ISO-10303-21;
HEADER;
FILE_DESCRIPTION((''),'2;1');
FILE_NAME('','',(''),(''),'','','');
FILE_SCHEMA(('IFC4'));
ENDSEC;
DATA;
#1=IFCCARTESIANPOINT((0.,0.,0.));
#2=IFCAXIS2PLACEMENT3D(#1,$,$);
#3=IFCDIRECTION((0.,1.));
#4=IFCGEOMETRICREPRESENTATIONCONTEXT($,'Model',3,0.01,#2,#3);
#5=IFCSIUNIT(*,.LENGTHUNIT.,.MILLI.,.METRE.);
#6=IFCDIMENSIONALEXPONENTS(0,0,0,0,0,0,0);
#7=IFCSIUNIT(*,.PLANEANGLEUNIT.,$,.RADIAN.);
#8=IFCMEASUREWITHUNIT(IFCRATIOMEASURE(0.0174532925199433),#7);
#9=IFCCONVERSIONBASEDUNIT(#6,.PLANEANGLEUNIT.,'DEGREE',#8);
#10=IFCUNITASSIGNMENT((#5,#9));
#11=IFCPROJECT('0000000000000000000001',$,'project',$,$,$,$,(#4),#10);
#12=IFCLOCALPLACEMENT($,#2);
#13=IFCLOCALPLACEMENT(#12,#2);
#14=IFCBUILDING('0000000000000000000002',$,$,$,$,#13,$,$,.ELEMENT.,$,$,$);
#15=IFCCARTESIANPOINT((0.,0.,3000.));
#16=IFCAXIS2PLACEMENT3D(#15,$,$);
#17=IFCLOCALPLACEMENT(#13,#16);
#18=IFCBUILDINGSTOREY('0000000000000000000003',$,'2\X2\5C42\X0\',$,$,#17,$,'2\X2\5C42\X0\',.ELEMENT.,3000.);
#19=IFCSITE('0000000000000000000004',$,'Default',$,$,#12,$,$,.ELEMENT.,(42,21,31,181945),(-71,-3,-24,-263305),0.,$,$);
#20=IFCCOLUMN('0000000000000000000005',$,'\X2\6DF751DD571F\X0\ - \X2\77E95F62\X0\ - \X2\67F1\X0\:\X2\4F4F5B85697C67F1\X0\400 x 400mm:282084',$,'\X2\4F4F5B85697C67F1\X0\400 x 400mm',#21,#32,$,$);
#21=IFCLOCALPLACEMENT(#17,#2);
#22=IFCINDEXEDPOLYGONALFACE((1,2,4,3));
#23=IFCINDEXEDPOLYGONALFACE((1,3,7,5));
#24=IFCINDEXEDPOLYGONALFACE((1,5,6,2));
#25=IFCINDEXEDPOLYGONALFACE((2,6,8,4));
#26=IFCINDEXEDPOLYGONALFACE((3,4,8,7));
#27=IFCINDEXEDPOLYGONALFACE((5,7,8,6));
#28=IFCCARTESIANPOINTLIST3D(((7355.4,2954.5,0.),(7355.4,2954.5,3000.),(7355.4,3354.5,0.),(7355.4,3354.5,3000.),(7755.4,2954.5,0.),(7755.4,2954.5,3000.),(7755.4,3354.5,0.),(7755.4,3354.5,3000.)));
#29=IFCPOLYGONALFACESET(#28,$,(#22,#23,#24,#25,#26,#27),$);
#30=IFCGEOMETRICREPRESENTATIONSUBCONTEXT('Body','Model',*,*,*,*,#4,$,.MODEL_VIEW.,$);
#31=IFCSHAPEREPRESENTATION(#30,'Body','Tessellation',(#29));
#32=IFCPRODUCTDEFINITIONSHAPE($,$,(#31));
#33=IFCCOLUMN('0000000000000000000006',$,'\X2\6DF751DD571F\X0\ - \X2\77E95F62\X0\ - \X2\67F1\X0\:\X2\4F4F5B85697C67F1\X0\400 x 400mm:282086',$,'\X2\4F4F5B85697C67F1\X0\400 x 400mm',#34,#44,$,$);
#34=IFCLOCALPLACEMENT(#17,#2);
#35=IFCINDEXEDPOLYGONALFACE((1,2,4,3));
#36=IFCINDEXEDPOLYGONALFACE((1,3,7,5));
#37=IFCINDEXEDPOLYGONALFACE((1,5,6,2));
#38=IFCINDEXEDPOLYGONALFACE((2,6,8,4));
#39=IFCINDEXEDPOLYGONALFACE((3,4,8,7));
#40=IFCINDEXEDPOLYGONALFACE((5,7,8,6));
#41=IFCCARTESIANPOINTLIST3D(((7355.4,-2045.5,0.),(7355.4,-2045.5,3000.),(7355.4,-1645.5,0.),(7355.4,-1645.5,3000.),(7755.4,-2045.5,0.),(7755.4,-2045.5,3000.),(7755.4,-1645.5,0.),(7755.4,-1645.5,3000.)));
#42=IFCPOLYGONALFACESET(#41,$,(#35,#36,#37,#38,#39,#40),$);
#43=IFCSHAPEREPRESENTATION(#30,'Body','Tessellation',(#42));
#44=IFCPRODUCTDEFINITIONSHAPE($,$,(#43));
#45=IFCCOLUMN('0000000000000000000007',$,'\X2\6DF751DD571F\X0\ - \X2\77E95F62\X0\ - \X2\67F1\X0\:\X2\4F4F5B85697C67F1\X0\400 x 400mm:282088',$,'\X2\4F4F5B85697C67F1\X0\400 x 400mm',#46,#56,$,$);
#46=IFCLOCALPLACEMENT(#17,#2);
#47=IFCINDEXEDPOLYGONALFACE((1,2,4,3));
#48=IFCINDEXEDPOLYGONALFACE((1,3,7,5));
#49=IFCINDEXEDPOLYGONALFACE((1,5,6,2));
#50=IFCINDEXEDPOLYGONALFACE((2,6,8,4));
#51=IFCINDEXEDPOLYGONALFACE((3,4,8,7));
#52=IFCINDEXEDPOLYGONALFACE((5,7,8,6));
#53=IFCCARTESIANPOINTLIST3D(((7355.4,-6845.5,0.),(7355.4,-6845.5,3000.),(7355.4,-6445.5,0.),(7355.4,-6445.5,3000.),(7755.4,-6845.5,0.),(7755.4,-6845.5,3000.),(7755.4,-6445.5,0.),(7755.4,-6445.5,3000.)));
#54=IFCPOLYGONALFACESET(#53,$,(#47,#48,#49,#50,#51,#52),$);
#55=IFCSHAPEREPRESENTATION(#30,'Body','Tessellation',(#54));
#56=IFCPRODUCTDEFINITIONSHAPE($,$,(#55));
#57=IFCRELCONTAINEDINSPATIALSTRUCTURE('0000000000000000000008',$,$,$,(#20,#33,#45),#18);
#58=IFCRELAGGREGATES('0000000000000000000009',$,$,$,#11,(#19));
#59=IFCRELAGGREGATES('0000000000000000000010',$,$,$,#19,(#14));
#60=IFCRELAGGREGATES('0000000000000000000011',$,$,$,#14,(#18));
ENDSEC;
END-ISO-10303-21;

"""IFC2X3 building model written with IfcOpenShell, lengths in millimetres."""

from ifc_helpers import new_model, entity, si_unit, converted_unit, direction, frame, origin, origin_2d_with_axis, place, context, subcontext, project, spatial, rectangle, extrude, source, transform, mapped, element, save


model = new_model("IFC2X3")

# Units and contexts
model_context = context("Model", 3, precision=0.01, world=origin(), true_north=direction((0.0, 1.0)))
body_context = subcontext(model_context, "Body", "Model", "MODEL_VIEW")
ifc_project = project(units=[si_unit("LENGTHUNIT", "METRE", prefix="MILLI"), converted_unit("PLANEANGLEUNIT", "DEGREE", entity("IfcRatioMeasure", 0.0174532925199433), si_unit("PLANEANGLEUNIT", "RADIAN"), dimensions=[0, 0, 0, 0, 0, 0, 0])], contexts=[model_context])

# Site, building, storey
site_placement = place(None, origin())
site = spatial("IfcSite", under=ifc_project, at=site_placement, Name="Default", CompositionType="ELEMENT", RefLatitude=(42, 21, 31, 181945), RefLongitude=(-71, -3, -24, -263305), RefElevation=0.0)
building_placement = place(site_placement, origin())
building = spatial("IfcBuilding", under=site, at=building_placement, CompositionType="ELEMENT")
storey_placement = place(building_placement, frame((0.0, 0.0, 3000.0)))
storey = spatial("IfcBuildingStorey", under=building, at=storey_placement, Name="2层", LongName="2层", CompositionType="ELEMENT", Elevation=3000.0)

# Columns
shared_shape_1 = source(origin(), body_context, "Body", "SweptSolid", [
    extrude(rectangle(XDim=400.0, YDim=400.0, at=origin_2d_with_axis()), frame((7555.4, 3154.5, 3000.0), z_axis=(0.0, 0.0, 1.0), x_axis=(0.0, -1.0, 0.0)), (0.0, 0.0, 1.0), 3000.0),
])
column_1_placement = place(storey_placement, frame((0.0, 0.0, -3000.0)))
element("IfcColumn", 1, at=column_1_placement, inside=storey, Name="混凝土 - 矩形 - 柱:住宅楼柱400 x 400mm:282084", ObjectType="住宅楼柱400 x 400mm", context=body_context, shape_type="MappedRepresentation", body=[
    mapped(shared_shape_1, transform((0.0, 0.0, 0.0), scale=1.0)),
])
shared_shape_2 = source(origin(), body_context, "Body", "SweptSolid", [
    extrude(rectangle(XDim=400.0, YDim=400.0, at=origin_2d_with_axis()), frame((7555.4, -1845.5, 3000.0), z_axis=(0.0, 0.0, 1.0), x_axis=(0.0, -1.0, 0.0)), (0.0, 0.0, 1.0), 3000.0),
])
column_2_placement = place(storey_placement, frame((0.0, 0.0, -3000.0)))
element("IfcColumn", 2, at=column_2_placement, inside=storey, Name="混凝土 - 矩形 - 柱:住宅楼柱400 x 400mm:282086", ObjectType="住宅楼柱400 x 400mm", context=body_context, shape_type="MappedRepresentation", body=[
    mapped(shared_shape_2, transform((0.0, 0.0, 0.0), scale=1.0)),
])
shared_shape_3 = source(origin(), body_context, "Body", "SweptSolid", [
    extrude(rectangle(XDim=400.0, YDim=400.0, at=origin_2d_with_axis()), frame((7555.4, -6645.5, 3000.0), z_axis=(0.0, 0.0, 1.0), x_axis=(0.0, -1.0, 0.0)), (0.0, 0.0, 1.0), 3000.0),
])
column_3_placement = place(storey_placement, frame((0.0, 0.0, -3000.0)))
element("IfcColumn", 3, at=column_3_placement, inside=storey, Name="混凝土 - 矩形 - 柱:住宅楼柱400 x 400mm:282088", ObjectType="住宅楼柱400 x 400mm", context=body_context, shape_type="MappedRepresentation", body=[
    mapped(shared_shape_3, transform((0.0, 0.0, 0.0), scale=1.0)),
])

save(model, "model.ifc")
